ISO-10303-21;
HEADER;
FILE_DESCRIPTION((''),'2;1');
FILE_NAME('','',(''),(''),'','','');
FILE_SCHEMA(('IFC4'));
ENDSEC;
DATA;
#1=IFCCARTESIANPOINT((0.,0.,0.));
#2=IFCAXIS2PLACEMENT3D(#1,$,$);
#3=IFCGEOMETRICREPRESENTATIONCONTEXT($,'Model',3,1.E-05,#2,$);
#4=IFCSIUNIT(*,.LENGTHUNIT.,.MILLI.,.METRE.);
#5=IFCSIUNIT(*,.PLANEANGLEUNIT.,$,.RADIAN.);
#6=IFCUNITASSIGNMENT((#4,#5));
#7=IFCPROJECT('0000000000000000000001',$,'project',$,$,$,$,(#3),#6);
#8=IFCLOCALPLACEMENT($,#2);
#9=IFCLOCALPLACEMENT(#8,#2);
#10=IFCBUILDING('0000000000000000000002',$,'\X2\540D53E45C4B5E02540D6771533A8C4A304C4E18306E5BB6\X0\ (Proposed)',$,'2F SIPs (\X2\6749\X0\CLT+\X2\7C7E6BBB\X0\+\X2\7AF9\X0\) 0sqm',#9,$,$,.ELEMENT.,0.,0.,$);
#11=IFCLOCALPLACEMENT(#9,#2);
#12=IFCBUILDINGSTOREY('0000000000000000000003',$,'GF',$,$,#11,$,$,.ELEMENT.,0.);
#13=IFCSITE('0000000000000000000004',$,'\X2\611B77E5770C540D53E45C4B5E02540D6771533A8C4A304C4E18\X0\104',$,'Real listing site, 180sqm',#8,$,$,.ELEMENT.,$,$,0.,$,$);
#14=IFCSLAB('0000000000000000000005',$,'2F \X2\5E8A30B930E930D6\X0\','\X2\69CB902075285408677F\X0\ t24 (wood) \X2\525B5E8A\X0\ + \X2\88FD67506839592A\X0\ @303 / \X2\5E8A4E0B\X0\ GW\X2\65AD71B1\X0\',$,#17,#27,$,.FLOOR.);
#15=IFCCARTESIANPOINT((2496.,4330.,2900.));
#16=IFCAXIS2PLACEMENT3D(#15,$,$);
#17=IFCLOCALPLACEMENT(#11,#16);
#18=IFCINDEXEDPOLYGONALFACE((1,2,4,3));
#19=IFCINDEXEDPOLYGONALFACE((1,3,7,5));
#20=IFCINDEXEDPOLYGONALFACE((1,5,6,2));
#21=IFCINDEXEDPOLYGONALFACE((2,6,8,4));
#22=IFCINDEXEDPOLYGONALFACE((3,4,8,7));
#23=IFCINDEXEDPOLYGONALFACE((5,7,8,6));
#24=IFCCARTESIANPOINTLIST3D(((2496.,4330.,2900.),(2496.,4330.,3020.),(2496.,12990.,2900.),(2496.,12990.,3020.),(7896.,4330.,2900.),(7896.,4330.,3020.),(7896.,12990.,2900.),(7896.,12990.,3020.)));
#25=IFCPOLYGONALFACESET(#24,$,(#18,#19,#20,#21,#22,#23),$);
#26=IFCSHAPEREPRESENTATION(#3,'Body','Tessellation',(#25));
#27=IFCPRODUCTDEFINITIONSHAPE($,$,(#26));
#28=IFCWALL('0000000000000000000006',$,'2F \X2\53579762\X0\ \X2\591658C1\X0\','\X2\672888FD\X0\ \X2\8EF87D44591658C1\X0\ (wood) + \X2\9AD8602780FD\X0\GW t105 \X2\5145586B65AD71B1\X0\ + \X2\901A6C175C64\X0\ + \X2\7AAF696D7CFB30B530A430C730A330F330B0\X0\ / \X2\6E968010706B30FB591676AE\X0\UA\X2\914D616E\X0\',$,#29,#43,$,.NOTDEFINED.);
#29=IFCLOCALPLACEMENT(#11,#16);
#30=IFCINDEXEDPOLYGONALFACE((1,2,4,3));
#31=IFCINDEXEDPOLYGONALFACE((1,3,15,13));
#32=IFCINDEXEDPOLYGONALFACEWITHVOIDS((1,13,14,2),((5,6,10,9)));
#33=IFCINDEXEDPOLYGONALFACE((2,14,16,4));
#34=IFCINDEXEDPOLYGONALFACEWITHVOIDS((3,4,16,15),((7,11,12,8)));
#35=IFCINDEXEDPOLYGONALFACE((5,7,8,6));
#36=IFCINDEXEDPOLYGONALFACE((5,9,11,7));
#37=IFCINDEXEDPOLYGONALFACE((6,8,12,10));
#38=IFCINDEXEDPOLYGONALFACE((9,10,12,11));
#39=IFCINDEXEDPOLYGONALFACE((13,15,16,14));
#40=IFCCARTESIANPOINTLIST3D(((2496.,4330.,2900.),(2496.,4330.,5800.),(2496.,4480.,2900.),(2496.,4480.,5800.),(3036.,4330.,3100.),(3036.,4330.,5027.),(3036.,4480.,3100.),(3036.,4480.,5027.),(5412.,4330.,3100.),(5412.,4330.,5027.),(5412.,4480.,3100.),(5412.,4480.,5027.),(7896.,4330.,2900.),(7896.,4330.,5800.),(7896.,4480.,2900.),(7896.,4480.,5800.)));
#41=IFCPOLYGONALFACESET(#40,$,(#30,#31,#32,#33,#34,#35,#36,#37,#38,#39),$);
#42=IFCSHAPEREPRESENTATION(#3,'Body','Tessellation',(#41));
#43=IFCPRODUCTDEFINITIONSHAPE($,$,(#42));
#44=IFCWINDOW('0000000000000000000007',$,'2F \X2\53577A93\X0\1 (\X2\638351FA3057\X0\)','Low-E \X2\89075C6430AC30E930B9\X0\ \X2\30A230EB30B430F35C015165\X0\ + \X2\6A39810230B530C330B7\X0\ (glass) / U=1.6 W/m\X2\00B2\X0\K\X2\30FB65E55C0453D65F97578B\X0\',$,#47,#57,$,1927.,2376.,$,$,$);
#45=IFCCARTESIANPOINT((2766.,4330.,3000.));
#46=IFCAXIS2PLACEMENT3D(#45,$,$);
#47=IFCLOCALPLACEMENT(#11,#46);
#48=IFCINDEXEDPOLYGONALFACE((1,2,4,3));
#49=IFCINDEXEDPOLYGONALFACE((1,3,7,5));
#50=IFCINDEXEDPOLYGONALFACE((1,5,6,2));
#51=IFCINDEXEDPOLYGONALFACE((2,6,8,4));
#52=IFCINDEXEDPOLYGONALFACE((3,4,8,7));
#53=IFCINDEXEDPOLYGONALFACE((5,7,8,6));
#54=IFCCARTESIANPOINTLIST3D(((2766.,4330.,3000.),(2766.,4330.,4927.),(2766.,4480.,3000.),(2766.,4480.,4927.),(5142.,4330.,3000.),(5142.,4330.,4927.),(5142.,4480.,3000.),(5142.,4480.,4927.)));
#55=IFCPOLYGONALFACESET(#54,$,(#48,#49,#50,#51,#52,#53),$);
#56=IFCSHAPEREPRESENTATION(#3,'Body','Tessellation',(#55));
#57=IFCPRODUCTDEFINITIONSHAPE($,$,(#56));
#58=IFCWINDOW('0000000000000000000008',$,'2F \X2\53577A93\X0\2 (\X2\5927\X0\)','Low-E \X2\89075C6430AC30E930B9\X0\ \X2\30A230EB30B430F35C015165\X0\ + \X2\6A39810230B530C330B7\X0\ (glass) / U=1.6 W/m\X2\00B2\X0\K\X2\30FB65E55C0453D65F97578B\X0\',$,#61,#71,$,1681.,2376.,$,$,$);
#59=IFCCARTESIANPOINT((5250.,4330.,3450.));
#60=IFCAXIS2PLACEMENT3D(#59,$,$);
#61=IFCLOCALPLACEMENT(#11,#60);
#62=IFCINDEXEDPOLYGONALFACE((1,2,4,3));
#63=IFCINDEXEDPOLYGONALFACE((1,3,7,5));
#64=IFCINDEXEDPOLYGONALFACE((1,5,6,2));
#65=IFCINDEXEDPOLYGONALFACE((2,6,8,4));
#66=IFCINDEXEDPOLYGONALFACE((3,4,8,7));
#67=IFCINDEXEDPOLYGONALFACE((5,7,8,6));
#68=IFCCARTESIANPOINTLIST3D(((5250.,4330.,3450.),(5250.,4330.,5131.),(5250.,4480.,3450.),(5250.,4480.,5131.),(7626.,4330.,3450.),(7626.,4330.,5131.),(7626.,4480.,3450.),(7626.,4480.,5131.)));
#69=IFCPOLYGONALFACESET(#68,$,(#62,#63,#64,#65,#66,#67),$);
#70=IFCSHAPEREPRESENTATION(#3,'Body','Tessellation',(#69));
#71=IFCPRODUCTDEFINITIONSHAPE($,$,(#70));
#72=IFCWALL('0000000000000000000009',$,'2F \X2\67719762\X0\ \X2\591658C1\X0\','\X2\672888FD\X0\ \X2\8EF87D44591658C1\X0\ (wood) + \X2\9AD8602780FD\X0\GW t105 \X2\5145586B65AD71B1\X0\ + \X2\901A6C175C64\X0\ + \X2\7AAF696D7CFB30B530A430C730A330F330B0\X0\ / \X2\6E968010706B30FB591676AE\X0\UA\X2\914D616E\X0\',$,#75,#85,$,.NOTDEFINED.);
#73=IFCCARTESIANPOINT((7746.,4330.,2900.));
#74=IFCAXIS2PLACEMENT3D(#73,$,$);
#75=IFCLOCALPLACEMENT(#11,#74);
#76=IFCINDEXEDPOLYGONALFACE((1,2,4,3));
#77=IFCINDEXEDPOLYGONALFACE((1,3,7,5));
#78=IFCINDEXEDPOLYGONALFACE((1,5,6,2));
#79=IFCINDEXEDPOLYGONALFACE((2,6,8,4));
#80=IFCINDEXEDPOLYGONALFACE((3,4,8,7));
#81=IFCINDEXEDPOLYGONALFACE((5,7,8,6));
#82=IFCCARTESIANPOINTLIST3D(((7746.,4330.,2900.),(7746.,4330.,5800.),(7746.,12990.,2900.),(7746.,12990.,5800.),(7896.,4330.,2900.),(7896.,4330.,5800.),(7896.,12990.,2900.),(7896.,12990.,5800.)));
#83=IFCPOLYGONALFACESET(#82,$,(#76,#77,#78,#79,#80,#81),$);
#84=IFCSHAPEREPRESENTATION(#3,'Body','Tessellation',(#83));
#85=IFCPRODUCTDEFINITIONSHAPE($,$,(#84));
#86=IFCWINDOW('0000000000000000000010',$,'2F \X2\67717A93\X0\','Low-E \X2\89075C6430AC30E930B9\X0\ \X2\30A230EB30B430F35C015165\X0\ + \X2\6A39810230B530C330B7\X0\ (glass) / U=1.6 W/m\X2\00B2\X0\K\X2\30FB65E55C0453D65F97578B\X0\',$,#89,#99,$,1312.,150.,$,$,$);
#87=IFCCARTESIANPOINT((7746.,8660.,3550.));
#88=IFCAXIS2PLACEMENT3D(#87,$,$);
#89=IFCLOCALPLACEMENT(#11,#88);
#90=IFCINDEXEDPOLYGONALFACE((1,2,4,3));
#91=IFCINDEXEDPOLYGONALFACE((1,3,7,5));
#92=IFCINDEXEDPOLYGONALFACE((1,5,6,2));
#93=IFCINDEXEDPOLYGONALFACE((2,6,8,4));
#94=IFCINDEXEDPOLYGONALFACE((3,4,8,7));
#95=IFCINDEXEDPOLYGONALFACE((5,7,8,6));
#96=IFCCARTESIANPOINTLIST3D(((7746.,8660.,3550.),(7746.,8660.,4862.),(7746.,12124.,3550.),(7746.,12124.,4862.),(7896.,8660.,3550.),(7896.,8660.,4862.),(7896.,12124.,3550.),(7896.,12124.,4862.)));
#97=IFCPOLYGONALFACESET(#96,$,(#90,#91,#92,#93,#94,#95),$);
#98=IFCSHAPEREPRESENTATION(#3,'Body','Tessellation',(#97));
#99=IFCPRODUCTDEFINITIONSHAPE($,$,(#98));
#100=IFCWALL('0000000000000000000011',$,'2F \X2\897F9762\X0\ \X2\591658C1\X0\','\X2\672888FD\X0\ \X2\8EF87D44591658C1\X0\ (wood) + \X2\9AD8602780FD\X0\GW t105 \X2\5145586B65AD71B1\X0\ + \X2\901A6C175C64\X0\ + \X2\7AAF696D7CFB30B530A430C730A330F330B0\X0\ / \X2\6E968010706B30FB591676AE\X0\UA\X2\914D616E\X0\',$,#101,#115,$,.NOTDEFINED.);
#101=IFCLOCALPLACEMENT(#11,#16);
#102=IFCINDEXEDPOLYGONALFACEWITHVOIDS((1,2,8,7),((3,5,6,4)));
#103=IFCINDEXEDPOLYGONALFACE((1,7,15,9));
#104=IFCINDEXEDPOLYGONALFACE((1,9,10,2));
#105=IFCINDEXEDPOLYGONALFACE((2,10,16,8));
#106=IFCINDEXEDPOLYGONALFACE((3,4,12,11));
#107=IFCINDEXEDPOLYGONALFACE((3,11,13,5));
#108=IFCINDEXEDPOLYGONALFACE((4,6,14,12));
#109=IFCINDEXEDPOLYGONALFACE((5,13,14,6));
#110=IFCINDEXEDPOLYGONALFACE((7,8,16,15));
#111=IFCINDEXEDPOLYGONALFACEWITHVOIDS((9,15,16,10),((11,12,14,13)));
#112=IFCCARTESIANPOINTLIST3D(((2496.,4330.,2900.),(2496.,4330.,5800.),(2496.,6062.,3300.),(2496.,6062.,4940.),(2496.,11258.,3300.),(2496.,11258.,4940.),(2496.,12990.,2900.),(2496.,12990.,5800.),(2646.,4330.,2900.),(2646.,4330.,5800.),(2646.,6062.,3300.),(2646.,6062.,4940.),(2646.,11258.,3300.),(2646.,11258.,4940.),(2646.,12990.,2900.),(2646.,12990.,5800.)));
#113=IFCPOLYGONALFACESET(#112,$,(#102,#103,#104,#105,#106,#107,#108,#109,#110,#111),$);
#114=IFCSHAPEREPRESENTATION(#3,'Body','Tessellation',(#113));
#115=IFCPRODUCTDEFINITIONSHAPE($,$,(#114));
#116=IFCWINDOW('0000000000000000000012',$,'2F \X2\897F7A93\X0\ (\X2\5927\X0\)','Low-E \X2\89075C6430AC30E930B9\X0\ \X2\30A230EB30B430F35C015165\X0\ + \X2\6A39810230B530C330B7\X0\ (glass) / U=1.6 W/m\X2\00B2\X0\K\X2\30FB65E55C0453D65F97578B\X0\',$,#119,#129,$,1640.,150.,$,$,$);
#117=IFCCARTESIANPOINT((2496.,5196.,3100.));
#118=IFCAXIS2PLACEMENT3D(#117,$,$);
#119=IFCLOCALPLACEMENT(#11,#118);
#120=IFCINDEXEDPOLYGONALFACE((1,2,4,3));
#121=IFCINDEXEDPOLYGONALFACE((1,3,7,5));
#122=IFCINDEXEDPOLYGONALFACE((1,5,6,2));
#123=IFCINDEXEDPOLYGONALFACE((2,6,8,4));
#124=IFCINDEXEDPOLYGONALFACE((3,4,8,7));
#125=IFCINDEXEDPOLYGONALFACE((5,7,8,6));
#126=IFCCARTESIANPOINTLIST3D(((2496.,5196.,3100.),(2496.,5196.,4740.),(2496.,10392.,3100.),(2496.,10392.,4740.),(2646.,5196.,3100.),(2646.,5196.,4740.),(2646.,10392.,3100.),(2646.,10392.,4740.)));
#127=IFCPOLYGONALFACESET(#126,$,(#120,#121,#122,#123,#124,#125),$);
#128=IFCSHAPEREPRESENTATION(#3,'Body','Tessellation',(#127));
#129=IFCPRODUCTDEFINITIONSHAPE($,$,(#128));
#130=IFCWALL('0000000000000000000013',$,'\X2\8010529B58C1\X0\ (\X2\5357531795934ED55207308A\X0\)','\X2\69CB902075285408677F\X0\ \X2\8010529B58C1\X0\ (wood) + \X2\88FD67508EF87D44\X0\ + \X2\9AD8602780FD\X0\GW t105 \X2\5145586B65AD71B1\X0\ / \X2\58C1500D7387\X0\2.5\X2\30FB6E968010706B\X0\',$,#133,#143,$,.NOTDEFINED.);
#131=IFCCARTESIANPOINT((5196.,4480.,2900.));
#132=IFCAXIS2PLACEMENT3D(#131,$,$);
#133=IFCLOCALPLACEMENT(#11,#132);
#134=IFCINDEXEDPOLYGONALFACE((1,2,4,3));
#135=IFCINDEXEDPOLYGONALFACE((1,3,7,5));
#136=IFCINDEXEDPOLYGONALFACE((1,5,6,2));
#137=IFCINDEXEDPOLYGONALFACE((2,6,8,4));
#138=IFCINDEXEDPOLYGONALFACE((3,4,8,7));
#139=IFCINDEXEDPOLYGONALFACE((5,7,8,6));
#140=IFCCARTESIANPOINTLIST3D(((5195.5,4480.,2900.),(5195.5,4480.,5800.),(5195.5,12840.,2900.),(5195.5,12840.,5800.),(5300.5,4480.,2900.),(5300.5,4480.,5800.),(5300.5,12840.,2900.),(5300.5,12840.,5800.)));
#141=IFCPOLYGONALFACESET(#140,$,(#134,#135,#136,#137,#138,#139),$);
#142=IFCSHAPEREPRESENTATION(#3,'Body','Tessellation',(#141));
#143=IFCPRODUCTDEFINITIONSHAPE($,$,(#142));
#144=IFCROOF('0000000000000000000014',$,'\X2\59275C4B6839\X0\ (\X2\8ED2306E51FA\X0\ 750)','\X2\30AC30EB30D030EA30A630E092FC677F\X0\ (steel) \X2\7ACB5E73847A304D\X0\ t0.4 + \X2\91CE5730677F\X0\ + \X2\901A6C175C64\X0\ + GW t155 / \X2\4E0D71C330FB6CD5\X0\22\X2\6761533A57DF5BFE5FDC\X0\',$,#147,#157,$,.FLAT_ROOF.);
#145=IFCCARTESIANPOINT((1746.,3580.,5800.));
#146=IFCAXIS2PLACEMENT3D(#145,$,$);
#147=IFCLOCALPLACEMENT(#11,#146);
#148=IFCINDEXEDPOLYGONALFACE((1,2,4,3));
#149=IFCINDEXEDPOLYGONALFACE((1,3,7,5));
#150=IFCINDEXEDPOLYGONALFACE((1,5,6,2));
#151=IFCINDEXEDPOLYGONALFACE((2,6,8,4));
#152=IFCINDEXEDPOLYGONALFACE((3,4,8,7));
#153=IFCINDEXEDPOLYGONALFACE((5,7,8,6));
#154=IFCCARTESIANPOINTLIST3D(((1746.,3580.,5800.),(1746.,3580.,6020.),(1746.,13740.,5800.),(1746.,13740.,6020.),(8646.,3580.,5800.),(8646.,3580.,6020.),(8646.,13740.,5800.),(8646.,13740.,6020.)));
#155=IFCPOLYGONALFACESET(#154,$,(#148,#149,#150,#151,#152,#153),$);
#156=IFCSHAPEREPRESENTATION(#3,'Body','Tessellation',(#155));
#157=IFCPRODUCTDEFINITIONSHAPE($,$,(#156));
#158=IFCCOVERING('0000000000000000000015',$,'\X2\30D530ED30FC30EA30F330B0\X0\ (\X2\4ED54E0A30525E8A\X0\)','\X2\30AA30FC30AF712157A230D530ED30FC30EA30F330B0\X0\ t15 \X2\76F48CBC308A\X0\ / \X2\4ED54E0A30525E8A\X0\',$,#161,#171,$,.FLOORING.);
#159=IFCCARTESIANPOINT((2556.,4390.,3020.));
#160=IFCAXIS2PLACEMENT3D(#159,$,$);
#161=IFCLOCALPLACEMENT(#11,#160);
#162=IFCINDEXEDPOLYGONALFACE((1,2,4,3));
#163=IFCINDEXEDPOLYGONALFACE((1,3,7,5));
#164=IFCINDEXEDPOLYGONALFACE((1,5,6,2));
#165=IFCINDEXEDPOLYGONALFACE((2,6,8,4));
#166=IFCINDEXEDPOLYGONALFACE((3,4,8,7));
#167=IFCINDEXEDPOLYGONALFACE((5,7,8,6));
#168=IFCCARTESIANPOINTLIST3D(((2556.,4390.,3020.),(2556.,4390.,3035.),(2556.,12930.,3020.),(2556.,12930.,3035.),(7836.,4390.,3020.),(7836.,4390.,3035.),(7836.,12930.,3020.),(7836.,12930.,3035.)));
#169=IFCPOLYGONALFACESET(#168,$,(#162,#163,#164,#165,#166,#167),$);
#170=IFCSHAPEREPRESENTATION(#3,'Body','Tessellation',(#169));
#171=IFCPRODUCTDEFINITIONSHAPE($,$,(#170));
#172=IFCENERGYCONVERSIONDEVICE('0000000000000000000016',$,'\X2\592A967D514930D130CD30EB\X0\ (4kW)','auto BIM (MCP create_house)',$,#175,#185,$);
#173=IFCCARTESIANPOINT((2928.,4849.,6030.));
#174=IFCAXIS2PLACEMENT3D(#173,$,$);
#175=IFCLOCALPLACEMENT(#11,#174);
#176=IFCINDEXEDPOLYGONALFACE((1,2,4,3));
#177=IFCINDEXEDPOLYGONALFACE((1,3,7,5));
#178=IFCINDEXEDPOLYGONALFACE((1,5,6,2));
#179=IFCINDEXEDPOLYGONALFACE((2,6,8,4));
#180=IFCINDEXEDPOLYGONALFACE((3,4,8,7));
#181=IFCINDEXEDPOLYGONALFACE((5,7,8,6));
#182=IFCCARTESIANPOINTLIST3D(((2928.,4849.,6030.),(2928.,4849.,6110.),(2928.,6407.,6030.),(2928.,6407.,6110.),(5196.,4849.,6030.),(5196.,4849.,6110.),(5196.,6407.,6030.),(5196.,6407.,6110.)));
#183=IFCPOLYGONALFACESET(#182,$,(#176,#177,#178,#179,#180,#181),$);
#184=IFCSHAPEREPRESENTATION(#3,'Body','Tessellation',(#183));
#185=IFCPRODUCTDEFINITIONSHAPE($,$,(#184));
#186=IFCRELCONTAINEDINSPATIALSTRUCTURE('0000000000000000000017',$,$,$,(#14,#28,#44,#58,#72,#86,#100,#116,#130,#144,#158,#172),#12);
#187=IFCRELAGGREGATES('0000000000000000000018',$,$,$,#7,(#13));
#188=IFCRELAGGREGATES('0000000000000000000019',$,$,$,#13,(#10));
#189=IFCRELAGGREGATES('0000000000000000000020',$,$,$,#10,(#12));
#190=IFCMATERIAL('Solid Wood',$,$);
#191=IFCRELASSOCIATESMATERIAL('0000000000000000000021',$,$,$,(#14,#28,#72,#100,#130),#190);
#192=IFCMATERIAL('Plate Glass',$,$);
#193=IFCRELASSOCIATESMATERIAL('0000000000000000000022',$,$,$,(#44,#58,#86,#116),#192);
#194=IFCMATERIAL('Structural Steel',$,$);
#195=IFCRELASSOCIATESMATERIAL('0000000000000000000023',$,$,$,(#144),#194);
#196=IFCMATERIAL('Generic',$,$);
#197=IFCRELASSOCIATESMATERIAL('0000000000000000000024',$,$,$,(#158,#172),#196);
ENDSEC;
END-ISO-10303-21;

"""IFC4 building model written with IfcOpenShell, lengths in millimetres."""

from ifc_helpers import new_model, si_unit, frame, frame_2d, origin, place, context, project, spatial, rectangle, extrude, material, element, fill, save


model = new_model("IFC4")

# Units and contexts
model_context = context("Model", 3, precision=1e-05, world=origin())
ifc_project = project(units=[si_unit("LENGTHUNIT", "METRE", prefix="MILLI"), si_unit("PLANEANGLEUNIT", "RADIAN")], contexts=[model_context])

# Site, building, storey
site_placement = place(None, origin())
site = spatial("IfcSite", under=ifc_project, at=site_placement, Name="愛知県名古屋市名東区豊が丘104", ObjectType="Real listing site, 180sqm", CompositionType="ELEMENT", RefElevation=0.0)
building_placement = place(site_placement, origin())
building = spatial("IfcBuilding", under=site, at=building_placement, Name="名古屋市名東区豊が丘の家 (Proposed)", ObjectType="2F SIPs (杉CLT+籾殻+竹) 0sqm", CompositionType="ELEMENT", ElevationOfRefHeight=0.0, ElevationOfTerrain=0.0)
storey_placement = place(building_placement, origin())
storey = spatial("IfcBuildingStorey", under=building, at=storey_placement, Name="GF", CompositionType="ELEMENT", Elevation=0.0)

# Slab
ifc_material_1 = material(Name="Solid Wood")
slab_placement = place(storey_placement, frame((2496.0, 4330.0, 2900.0)))
element("IfcSlab", 1, at=slab_placement, inside=storey, material=ifc_material_1, Name="2F 床スラブ", Description="構造用合板 t24 (wood) 剛床 + 製材根太 @303 / 床下 GW断熱", PredefinedType="FLOOR", context=model_context, shape_type="SweptSolid", body=[
    extrude(rectangle(XDim=5400.0, YDim=8660.0, at=frame_2d((2700.0, 4330.0))), frame((2496.0, 4330.0, 2900.0)), (0.0, 0.0, 1.0), 120.0),
])

# Wall, openings, windows
wall_1_placement = place(storey_placement, frame((2496.0, 4330.0, 2900.0)))
wall_1 = element("IfcWall", 2, at=wall_1_placement, inside=storey, material=ifc_material_1, Name="2F 南面 外壁", Description="木製 軸組外壁 (wood) + 高性能GW t105 充填断熱 + 通気層 + 窯業系サイディング / 準耐火・外皮UA配慮", PredefinedType="NOTDEFINED", context=model_context, shape_type="SweptSolid", body=[
    extrude(rectangle(XDim=5400.0, YDim=150.0, at=frame_2d((2700.0, 75.0))), frame((2496.0, 4330.0, 2900.0)), (0.0, 0.0, 1.0), 2900.0),
])
opening_1_placement = place(storey_placement, frame((2766.0, 4330.0, 3000.0)))
opening_1 = element("IfcOpeningElement", 3, at=opening_1_placement, cuts=wall_1, PredefinedType="NOTDEFINED", context=model_context, shape_type="SweptSolid", body=[
    extrude(rectangle(XDim=2376.0, YDim=150.0, at=frame_2d((1188.0, 75.0))), frame((2766.0, 4330.0, 3000.0)), (0.0, 0.0, 1.0), 1927.0),
])
opening_2_placement = place(storey_placement, frame((5250.0, 4330.0, 3450.0)))
opening_2 = element("IfcOpeningElement", 4, at=opening_2_placement, cuts=wall_1, PredefinedType="NOTDEFINED", context=model_context, shape_type="SweptSolid", body=[
    extrude(rectangle(XDim=2376.0, YDim=150.0, at=frame_2d((1188.0, 75.0))), frame((5250.0, 4330.0, 3450.0)), (0.0, 0.0, 1.0), 1681.0),
])
ifc_material_2 = material(Name="Plate Glass")
window_1_placement = place(storey_placement, frame((2766.0, 4330.0, 3000.0)))
window_1 = element("IfcWindow", 5, at=window_1_placement, inside=storey, material=ifc_material_2, Name="2F 南窓1 (掃出し)", Description="Low-E 複層ガラス アルゴン封入 + 樹脂サッシ (glass) / U=1.6 W/m²K・日射取得型", OverallHeight=1927.0, OverallWidth=2376.0, context=model_context, shape_type="SweptSolid", body=[
    extrude(rectangle(XDim=2376.0, YDim=150.0, at=frame_2d((1188.0, 75.0))), frame((2766.0, 4330.0, 3000.0)), (0.0, 0.0, 1.0), 1927.0),
])
fill(opening_1, window_1)
window_2_placement = place(storey_placement, frame((5250.0, 4330.0, 3450.0)))
window_2 = element("IfcWindow", 6, at=window_2_placement, inside=storey, material=ifc_material_2, Name="2F 南窓2 (大)", Description="Low-E 複層ガラス アルゴン封入 + 樹脂サッシ (glass) / U=1.6 W/m²K・日射取得型", OverallHeight=1681.0, OverallWidth=2376.0, context=model_context, shape_type="SweptSolid", body=[
    extrude(rectangle(XDim=2376.0, YDim=150.0, at=frame_2d((1188.0, 75.0))), frame((5250.0, 4330.0, 3450.0)), (0.0, 0.0, 1.0), 1681.0),
])
fill(opening_2, window_2)

# Walls, openings, windows
wall_2_placement = place(storey_placement, frame((7746.0, 4330.0, 2900.0)))
wall_2 = element("IfcWall", 7, at=wall_2_placement, inside=storey, material=ifc_material_1, Name="2F 東面 外壁", Description="木製 軸組外壁 (wood) + 高性能GW t105 充填断熱 + 通気層 + 窯業系サイディング / 準耐火・外皮UA配慮", PredefinedType="NOTDEFINED", context=model_context, shape_type="SweptSolid", body=[
    extrude(rectangle(XDim=150.0, YDim=8660.0, at=frame_2d((75.0, 4330.0))), frame((7746.0, 4330.0, 2900.0)), (0.0, 0.0, 1.0), 2900.0),
])
opening_3_placement = place(storey_placement, frame((7746.0, 8660.0, 3550.0)))
opening_3 = element("IfcOpeningElement", 8, at=opening_3_placement, cuts=wall_2, PredefinedType="NOTDEFINED", context=model_context, shape_type="SweptSolid", body=[
    extrude(rectangle(XDim=150.0, YDim=3464.0, at=frame_2d((75.0, 1732.0))), frame((7746.0, 8660.0, 3550.0)), (0.0, 0.0, 1.0), 1312.0),
])
window_3_placement = place(storey_placement, frame((7746.0, 8660.0, 3550.0)))
window_3 = element("IfcWindow", 9, at=window_3_placement, inside=storey, material=ifc_material_2, Name="2F 東窓", Description="Low-E 複層ガラス アルゴン封入 + 樹脂サッシ (glass) / U=1.6 W/m²K・日射取得型", OverallHeight=1312.0, OverallWidth=150.0, context=model_context, shape_type="SweptSolid", body=[
    extrude(rectangle(XDim=150.0, YDim=3464.0, at=frame_2d((75.0, 1732.0))), frame((7746.0, 8660.0, 3550.0)), (0.0, 0.0, 1.0), 1312.0),
])
fill(opening_3, window_3)
wall_3_placement = place(storey_placement, frame((2496.0, 4330.0, 2900.0)))
wall_3 = element("IfcWall", 10, at=wall_3_placement, inside=storey, material=ifc_material_1, Name="2F 西面 外壁", Description="木製 軸組外壁 (wood) + 高性能GW t105 充填断熱 + 通気層 + 窯業系サイディング / 準耐火・外皮UA配慮", PredefinedType="NOTDEFINED", context=model_context, shape_type="SweptSolid", body=[
    extrude(rectangle(XDim=150.0, YDim=8660.0, at=frame_2d((75.0, 4330.0))), frame((2496.0, 4330.0, 2900.0)), (0.0, 0.0, 1.0), 2900.0),
])
opening_4_placement = place(storey_placement, frame((2496.0, 5196.0, 3100.0)))
opening_4 = element("IfcOpeningElement", 11, at=opening_4_placement, cuts=wall_3, PredefinedType="NOTDEFINED", context=model_context, shape_type="SweptSolid", body=[
    extrude(rectangle(XDim=150.0, YDim=5196.0, at=frame_2d((75.0, 2598.0))), frame((2496.0, 5196.0, 3100.0)), (0.0, 0.0, 1.0), 1640.0),
])
window_4_placement = place(storey_placement, frame((2496.0, 5196.0, 3100.0)))
window_4 = element("IfcWindow", 12, at=window_4_placement, inside=storey, material=ifc_material_2, Name="2F 西窓 (大)", Description="Low-E 複層ガラス アルゴン封入 + 樹脂サッシ (glass) / U=1.6 W/m²K・日射取得型", OverallHeight=1640.0, OverallWidth=150.0, context=model_context, shape_type="SweptSolid", body=[
    extrude(rectangle(XDim=150.0, YDim=5196.0, at=frame_2d((75.0, 2598.0))), frame((2496.0, 5196.0, 3100.0)), (0.0, 0.0, 1.0), 1640.0),
])
fill(opening_4, window_4)

# Wall
wall_4_placement = place(storey_placement, frame((5196.0, 4480.0, 2900.0)))
element("IfcWall", 13, at=wall_4_placement, inside=storey, material=ifc_material_1, Name="耐力壁 (南北間仕切り)", Description="構造用合板 耐力壁 (wood) + 製材軸組 + 高性能GW t105 充填断熱 / 壁倍率2.5・準耐火", PredefinedType="NOTDEFINED", context=model_context, shape_type="SweptSolid", body=[
    extrude(rectangle(XDim=105.0, YDim=8360.0, at=frame_2d((52.0, 4180.0))), frame((5196.0, 4480.0, 2900.0)), (0.0, 0.0, 1.0), 2900.0),
])

# Roof
ifc_material_3 = material(Name="Structural Steel")
roof_placement = place(storey_placement, frame((1746.0, 3580.0, 5800.0)))
element("IfcRoof", 14, at=roof_placement, inside=storey, material=ifc_material_3, Name="大屋根 (軒の出 750)", Description="ガルバリウム鋼板 (steel) 立平葺き t0.4 + 野地板 + 通気層 + GW t155 / 不燃・法22条区域対応", PredefinedType="FLAT_ROOF", context=model_context, shape_type="SweptSolid", body=[
    extrude(rectangle(XDim=6900.0, YDim=10160.0, at=frame_2d((3450.0, 5080.0))), frame((1746.0, 3580.0, 5800.0)), (0.0, 0.0, 1.0), 220.0),
])

# Covering
ifc_material_4 = material(Name="Generic")
covering_placement = place(storey_placement, frame((2556.0, 4390.0, 3020.0)))
element("IfcCovering", 15, at=covering_placement, inside=storey, material=ifc_material_4, Name="フローリング (仕上げ床)", Description="オーク無垢フローリング t15 直貼り / 仕上げ床", PredefinedType="FLOORING", context=model_context, shape_type="SweptSolid", body=[
    extrude(rectangle(XDim=5280.0, YDim=8540.0, at=frame_2d((2640.0, 4270.0))), frame((2556.0, 4390.0, 3020.0)), (0.0, 0.0, 1.0), 15.0),
])

# Energy conversion device
energy_conversion_device_placement = place(storey_placement, frame((2928.0, 4849.0, 6030.0)))
element("IfcEnergyConversionDevice", 16, at=energy_conversion_device_placement, inside=storey, material=ifc_material_4, Name="太陽光パネル (4kW)", Description="auto BIM (MCP create_house)", context=model_context, shape_type="SweptSolid", body=[
    extrude(rectangle(XDim=2268.0, YDim=1558.0, at=frame_2d((1134.0, 779.0))), frame((2928.0, 4849.0, 6030.0)), (0.0, 0.0, 1.0), 80.0),
])

save(model, "model.ifc")
